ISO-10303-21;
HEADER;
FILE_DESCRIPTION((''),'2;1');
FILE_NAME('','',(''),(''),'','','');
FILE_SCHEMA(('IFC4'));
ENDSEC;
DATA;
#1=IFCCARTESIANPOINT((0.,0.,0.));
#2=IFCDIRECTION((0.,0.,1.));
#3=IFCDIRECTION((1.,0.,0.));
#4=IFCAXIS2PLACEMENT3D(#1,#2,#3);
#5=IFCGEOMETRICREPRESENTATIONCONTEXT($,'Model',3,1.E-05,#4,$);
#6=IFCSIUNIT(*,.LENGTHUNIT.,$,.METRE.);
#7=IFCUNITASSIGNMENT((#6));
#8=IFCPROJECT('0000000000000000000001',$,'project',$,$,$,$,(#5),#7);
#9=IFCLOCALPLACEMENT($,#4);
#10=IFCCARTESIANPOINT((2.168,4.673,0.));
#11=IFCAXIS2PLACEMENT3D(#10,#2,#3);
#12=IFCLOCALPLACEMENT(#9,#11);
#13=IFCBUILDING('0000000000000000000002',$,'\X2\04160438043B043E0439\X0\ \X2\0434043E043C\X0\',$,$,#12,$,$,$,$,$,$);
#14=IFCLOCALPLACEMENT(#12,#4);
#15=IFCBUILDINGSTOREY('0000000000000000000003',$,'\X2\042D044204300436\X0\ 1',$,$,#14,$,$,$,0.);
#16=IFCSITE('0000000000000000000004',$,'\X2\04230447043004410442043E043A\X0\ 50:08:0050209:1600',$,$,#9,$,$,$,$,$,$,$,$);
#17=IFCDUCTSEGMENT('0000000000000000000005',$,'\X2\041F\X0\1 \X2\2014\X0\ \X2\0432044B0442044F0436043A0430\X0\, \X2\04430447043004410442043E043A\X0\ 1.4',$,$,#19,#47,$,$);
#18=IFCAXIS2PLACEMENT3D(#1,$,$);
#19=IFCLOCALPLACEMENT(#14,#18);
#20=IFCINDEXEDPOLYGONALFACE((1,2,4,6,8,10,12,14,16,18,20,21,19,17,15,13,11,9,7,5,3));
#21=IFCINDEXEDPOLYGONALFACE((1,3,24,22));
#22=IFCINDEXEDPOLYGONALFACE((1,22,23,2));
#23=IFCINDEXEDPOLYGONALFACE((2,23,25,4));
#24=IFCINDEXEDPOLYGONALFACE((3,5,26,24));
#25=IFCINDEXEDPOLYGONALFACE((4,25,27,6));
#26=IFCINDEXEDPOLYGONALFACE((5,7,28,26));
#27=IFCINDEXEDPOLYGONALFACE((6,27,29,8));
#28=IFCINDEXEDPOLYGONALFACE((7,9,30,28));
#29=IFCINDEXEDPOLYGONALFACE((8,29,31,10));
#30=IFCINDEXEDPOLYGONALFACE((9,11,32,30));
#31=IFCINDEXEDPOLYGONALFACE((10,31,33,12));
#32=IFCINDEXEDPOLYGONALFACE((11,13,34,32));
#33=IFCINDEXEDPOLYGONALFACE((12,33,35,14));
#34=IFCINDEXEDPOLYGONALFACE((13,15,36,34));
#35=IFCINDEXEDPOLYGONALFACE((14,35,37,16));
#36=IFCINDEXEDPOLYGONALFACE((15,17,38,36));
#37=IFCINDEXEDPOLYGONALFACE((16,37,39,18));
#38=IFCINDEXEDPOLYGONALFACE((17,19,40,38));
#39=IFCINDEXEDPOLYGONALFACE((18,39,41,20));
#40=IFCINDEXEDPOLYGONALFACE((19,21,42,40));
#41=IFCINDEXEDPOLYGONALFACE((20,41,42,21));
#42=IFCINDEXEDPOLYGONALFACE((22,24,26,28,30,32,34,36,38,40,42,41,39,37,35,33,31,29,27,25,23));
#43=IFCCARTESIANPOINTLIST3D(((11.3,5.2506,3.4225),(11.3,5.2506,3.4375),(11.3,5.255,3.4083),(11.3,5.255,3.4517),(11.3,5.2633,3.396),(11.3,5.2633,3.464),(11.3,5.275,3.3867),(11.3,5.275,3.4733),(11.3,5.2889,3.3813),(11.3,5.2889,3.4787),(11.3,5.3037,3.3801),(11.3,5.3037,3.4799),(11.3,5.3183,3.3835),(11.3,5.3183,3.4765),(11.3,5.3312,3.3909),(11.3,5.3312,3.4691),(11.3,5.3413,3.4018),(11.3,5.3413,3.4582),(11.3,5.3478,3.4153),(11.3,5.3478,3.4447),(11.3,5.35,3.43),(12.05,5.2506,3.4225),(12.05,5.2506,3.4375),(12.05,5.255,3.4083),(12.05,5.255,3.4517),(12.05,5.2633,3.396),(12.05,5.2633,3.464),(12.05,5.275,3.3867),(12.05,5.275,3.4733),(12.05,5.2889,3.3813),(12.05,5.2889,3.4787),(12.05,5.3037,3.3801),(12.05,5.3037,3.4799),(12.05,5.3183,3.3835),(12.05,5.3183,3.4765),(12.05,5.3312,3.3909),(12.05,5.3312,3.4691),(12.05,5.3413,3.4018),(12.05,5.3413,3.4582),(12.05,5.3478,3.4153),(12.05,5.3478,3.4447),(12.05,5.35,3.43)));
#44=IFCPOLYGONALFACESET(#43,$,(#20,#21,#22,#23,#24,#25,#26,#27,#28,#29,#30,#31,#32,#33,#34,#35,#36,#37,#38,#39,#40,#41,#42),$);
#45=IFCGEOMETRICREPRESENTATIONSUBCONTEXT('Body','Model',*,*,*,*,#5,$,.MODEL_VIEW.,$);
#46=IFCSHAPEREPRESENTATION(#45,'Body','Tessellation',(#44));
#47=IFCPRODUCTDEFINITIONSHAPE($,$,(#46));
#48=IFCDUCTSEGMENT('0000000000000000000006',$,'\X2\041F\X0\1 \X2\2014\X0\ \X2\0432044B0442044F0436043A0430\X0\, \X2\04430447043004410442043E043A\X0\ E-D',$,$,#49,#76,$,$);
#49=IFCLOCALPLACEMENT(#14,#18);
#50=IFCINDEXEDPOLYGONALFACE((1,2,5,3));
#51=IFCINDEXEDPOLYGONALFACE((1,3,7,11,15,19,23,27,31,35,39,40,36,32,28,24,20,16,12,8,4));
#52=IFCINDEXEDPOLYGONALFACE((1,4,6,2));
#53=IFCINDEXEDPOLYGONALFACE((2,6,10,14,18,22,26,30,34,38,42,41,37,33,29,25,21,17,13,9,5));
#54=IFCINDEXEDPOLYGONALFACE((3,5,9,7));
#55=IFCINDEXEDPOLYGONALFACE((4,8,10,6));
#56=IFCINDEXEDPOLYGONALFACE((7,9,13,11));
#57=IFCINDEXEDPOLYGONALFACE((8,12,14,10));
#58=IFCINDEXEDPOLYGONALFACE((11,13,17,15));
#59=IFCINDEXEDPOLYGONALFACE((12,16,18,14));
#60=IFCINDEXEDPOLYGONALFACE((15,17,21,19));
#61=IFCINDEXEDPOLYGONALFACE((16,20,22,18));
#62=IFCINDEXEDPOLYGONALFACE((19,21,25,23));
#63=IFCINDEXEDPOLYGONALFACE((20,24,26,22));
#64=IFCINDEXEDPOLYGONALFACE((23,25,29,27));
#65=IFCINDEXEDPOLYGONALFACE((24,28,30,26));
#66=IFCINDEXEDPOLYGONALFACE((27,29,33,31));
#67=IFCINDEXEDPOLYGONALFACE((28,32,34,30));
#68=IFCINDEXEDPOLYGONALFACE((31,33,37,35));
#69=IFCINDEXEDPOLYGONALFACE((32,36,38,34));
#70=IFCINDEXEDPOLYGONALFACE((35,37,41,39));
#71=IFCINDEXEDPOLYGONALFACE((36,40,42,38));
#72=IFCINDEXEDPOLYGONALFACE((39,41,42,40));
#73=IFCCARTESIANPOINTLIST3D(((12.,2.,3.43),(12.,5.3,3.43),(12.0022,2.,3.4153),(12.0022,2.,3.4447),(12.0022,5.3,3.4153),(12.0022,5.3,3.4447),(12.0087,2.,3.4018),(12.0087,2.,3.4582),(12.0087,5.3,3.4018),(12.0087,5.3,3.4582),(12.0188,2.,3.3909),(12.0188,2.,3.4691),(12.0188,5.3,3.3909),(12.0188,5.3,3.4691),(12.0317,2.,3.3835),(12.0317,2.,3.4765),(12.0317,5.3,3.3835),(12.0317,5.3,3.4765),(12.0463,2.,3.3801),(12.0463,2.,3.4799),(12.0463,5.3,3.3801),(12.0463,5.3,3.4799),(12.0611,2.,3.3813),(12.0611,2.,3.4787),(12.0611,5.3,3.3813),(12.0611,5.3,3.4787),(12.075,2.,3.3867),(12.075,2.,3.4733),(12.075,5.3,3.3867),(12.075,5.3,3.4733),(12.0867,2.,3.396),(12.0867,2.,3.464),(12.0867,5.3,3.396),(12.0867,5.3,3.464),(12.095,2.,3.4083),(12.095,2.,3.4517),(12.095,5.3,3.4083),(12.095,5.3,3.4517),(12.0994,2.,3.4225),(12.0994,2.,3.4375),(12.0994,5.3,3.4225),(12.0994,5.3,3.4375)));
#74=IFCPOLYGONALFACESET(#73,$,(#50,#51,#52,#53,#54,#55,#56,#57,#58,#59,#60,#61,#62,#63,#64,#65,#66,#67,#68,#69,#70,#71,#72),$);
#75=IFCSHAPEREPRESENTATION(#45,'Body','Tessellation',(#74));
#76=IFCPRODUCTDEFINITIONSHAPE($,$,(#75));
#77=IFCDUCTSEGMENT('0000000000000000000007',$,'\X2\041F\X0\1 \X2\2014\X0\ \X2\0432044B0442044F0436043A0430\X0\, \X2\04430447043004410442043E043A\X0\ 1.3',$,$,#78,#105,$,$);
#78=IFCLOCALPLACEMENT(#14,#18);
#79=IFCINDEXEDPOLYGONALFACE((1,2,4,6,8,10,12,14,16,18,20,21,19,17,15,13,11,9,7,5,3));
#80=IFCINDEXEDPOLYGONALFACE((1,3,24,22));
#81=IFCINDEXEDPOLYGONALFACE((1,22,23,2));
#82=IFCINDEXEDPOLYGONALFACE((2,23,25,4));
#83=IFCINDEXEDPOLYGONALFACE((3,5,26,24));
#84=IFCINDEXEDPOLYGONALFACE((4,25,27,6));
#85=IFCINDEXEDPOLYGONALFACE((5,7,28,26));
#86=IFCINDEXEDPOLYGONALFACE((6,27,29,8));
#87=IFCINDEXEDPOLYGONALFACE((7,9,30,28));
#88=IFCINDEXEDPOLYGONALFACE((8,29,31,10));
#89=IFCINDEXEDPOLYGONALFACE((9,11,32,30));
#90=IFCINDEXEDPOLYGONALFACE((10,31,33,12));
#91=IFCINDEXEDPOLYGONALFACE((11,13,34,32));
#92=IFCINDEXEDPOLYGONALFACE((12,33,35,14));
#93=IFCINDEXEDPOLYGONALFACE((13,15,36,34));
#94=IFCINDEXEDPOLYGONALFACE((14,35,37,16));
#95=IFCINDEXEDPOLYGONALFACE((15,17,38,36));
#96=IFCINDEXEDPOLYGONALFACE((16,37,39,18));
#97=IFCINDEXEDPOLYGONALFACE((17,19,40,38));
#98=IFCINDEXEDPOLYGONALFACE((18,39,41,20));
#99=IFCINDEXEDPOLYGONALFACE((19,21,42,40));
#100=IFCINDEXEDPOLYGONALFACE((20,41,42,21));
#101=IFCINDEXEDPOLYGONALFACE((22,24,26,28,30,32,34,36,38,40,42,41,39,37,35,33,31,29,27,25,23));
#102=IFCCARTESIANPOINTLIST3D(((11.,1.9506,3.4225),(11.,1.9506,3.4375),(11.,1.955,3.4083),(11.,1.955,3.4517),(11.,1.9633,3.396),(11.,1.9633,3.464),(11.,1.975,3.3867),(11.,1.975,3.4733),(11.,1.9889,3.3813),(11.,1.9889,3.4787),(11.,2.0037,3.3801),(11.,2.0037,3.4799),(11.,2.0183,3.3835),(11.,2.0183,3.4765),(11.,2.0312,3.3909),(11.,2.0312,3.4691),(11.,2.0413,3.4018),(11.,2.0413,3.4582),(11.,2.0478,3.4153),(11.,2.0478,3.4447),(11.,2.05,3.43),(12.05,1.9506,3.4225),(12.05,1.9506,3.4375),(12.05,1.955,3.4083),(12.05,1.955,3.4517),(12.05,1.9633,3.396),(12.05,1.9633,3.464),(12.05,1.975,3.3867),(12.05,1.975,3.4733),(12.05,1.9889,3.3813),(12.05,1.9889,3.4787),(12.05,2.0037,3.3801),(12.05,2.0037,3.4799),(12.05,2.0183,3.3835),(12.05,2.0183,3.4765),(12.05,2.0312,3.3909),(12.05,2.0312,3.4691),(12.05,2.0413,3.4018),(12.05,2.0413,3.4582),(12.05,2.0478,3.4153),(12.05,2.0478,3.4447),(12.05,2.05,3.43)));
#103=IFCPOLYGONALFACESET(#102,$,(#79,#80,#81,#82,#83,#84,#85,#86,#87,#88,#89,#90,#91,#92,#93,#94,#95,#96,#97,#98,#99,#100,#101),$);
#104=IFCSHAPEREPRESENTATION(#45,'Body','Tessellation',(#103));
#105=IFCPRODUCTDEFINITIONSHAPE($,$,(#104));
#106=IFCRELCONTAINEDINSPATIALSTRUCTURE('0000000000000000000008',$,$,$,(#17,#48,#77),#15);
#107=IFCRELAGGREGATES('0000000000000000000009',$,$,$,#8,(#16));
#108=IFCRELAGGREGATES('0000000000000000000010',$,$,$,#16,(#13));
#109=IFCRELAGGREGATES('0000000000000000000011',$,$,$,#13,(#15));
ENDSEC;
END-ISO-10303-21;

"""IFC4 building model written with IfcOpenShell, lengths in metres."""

from ifc_helpers import new_model, si_unit, frame, origin_with_axes, origin_2d, place, context, subcontext, project, spatial, circle, extrude, element, save


model = new_model("IFC4")

# Units and contexts
model_context = context("Model", 3, precision=1e-05, world=origin_with_axes())
body_context = subcontext(model_context, "Body", "Model", "MODEL_VIEW")
ifc_project = project(units=[si_unit("LENGTHUNIT", "METRE")], contexts=[model_context])

# Site, building, storey
site_placement = place(None, origin_with_axes())
site = spatial("IfcSite", under=ifc_project, at=site_placement, Name="Участок 50:08:0050209:1600")
building_placement = place(site_placement, frame((2.168, 4.673, 0.0), z_axis=(0.0, 0.0, 1.0), x_axis=(1.0, 0.0, 0.0)))
building = spatial("IfcBuilding", under=site, at=building_placement, Name="Жилой дом")
storey_placement = place(building_placement, origin_with_axes())
storey = spatial("IfcBuildingStorey", under=building, at=storey_placement, Name="Этаж 1", Elevation=0.0)

# Duct segments
duct_segment_1_placement = place(storey_placement, origin_with_axes())
element("IfcDuctSegment", 1, at=duct_segment_1_placement, inside=storey, Name="П1 — вытяжка, участок 1.4", context=body_context, shape_type="SweptSolid", body=[
    extrude(circle(Radius=0.05, at=origin_2d()), frame((11.3, 5.3, 3.43), z_axis=(1.0, 0.0, 0.0), x_axis=(0.0, 1.0, 0.0)), (0.0, 0.0, 1.0), 0.75),
])
duct_segment_2_placement = place(storey_placement, origin_with_axes())
element("IfcDuctSegment", 2, at=duct_segment_2_placement, inside=storey, Name="П1 — вытяжка, участок E-D", context=body_context, shape_type="SweptSolid", body=[
    extrude(circle(Radius=0.05, at=origin_2d()), frame((12.05, 2.0, 3.43), z_axis=(0.0, 1.0, 0.0), x_axis=(-1.0, 0.0, 0.0)), (0.0, 0.0, 1.0), 3.3),
])
duct_segment_3_placement = place(storey_placement, origin_with_axes())
element("IfcDuctSegment", 3, at=duct_segment_3_placement, inside=storey, Name="П1 — вытяжка, участок 1.3", context=body_context, shape_type="SweptSolid", body=[
    extrude(circle(Radius=0.05, at=origin_2d()), frame((11.0, 2.0, 3.43), z_axis=(1.0, 0.0, 0.0), x_axis=(0.0, 1.0, 0.0)), (0.0, 0.0, 1.0), 1.05),
])

save(model, "model.ifc")
